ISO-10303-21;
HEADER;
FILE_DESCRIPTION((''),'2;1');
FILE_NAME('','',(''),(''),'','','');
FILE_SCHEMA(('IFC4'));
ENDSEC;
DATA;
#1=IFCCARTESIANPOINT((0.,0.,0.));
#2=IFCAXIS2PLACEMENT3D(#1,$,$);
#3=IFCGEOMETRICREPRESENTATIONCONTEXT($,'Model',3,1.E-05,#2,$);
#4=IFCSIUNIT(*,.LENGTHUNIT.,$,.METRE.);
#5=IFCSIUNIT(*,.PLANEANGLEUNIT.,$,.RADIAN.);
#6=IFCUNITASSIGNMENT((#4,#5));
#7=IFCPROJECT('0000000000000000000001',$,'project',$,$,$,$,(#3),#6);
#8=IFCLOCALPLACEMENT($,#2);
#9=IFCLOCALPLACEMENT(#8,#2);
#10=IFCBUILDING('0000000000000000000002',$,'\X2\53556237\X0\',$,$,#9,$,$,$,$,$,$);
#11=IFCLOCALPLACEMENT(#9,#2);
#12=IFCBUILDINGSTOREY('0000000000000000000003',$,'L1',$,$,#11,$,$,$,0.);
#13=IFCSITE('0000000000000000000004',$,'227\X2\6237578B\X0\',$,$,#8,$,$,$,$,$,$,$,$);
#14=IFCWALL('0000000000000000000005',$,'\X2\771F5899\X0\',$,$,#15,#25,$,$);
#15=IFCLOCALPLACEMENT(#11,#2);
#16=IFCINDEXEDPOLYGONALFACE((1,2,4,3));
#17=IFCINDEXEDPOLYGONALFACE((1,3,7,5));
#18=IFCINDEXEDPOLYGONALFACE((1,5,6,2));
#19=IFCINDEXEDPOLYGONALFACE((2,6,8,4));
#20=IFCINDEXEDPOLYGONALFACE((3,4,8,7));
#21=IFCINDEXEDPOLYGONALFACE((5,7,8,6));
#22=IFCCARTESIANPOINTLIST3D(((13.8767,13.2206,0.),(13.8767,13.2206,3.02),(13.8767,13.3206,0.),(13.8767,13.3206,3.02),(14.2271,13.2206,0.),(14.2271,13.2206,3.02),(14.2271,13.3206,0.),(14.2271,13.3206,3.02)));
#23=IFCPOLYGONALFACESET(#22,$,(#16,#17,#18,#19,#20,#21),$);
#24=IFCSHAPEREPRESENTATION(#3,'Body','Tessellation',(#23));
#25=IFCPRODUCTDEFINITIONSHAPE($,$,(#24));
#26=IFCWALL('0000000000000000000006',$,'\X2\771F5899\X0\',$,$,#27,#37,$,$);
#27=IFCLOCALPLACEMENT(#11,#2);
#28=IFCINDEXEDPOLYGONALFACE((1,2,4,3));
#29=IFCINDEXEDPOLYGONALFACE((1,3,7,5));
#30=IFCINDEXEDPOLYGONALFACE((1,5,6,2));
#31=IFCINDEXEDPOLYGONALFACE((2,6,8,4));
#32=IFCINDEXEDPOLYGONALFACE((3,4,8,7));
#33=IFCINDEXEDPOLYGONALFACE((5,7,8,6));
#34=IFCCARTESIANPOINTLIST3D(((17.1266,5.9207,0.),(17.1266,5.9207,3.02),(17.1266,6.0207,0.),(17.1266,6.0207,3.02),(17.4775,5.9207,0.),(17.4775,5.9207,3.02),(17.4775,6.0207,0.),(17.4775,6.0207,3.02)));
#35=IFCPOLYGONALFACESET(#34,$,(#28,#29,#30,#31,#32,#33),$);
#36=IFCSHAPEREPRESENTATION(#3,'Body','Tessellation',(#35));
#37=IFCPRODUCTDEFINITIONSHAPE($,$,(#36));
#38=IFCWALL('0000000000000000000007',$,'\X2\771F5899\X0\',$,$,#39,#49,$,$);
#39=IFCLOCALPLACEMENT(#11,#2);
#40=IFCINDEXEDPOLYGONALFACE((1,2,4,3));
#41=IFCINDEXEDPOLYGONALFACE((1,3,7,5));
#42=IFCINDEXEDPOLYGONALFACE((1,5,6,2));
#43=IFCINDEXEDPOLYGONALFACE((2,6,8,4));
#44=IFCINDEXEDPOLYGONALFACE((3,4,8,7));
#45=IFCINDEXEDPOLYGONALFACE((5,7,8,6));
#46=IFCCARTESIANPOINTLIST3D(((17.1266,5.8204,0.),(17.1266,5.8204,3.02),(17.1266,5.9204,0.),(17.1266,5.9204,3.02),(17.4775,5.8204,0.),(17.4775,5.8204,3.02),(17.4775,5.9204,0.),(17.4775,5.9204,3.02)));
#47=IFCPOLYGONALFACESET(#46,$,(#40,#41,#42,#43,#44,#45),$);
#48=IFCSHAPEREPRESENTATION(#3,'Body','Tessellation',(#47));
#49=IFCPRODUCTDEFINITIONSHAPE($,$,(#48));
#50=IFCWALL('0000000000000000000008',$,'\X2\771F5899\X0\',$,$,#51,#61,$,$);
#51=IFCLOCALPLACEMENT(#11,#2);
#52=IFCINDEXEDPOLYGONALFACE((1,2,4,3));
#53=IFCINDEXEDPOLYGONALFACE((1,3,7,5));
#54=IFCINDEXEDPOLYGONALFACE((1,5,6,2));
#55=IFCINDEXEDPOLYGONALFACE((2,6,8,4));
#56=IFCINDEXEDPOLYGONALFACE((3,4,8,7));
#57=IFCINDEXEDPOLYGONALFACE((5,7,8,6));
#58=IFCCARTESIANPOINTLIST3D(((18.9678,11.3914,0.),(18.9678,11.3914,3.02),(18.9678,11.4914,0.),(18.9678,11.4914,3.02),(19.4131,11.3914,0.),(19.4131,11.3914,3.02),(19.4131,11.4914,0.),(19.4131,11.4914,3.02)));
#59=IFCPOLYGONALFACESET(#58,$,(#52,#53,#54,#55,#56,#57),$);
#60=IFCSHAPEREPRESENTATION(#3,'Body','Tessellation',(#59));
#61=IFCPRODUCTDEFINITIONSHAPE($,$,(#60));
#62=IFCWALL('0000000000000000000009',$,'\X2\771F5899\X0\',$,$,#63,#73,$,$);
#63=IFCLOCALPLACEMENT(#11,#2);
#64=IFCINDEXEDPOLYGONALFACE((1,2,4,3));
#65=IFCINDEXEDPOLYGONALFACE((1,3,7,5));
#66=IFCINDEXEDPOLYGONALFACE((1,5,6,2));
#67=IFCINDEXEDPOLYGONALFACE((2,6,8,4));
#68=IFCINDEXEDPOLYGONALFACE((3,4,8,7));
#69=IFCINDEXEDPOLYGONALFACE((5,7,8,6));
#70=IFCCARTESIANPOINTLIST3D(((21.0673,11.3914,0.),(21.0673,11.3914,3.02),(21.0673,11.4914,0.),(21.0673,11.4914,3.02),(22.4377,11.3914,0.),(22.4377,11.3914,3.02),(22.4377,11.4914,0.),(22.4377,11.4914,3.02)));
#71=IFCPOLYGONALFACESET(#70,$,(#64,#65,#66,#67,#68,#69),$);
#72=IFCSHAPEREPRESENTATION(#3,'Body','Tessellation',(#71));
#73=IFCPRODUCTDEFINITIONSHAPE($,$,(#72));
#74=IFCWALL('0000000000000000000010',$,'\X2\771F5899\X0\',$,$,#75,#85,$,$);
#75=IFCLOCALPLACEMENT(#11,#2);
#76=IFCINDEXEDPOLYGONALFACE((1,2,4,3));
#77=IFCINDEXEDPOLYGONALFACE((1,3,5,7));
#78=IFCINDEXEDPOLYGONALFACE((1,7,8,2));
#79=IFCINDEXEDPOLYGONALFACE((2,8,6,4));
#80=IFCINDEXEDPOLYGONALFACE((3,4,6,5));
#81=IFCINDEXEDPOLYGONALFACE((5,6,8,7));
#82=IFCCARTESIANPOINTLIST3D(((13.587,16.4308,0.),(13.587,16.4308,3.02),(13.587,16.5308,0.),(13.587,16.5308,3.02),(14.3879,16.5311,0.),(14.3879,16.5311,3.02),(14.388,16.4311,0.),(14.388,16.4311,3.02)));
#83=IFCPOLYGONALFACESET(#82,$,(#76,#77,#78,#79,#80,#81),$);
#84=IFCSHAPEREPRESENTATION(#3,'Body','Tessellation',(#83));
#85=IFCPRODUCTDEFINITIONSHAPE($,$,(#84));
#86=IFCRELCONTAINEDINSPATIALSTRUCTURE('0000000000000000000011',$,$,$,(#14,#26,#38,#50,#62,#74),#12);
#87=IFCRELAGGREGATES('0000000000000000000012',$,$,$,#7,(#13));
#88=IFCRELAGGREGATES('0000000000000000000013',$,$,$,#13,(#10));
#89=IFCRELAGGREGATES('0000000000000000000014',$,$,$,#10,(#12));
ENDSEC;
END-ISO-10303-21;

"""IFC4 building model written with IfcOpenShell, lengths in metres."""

from ifc_helpers import new_model, si_unit, origin, place, context, project, spatial, polyline, outline, extrude, element, save


model = new_model("IFC4")

# Units and contexts
model_context = context("Model", 3, precision=1e-05, world=origin())
ifc_project = project(units=[si_unit("LENGTHUNIT", "METRE"), si_unit("PLANEANGLEUNIT", "RADIAN")], contexts=[model_context])

# Site, building, storey
site_placement = place(None, origin())
site = spatial("IfcSite", under=ifc_project, at=site_placement, Name="227户型")
building_placement = place(site_placement, origin())
building = spatial("IfcBuilding", under=site, at=building_placement, Name="单户")
storey_placement = place(building_placement, origin())
storey = spatial("IfcBuildingStorey", under=building, at=storey_placement, Name="L1", Elevation=0.0)

# Walls
wall_1_placement = place(storey_placement, origin())
element("IfcWall", 1, at=wall_1_placement, inside=storey, Name="真墙", context=model_context, shape_type="SweptSolid", body=[
    extrude(outline(polyline([(13.8767, 13.3206), (14.2271, 13.3206), (14.2271, 13.2206), (13.8767, 13.2206), (13.8767, 13.3206)])), origin(), (0.0, 0.0, 1.0), 3.02),
])
wall_2_placement = place(storey_placement, origin())
element("IfcWall", 2, at=wall_2_placement, inside=storey, Name="真墙", context=model_context, shape_type="SweptSolid", body=[
    extrude(outline(polyline([(17.4775, 5.9207), (17.1266, 5.9207), (17.1266, 6.0207), (17.4775, 6.0207), (17.4775, 5.9207)])), origin(), (0.0, 0.0, 1.0), 3.02),
])
wall_3_placement = place(storey_placement, origin())
element("IfcWall", 3, at=wall_3_placement, inside=storey, Name="真墙", context=model_context, shape_type="SweptSolid", body=[
    extrude(outline(polyline([(17.1266, 5.9204), (17.4775, 5.9204), (17.4775, 5.8204), (17.1266, 5.8204), (17.1266, 5.9204)])), origin(), (0.0, 0.0, 1.0), 3.02),
])
wall_4_placement = place(storey_placement, origin())
element("IfcWall", 4, at=wall_4_placement, inside=storey, Name="真墙", context=model_context, shape_type="SweptSolid", body=[
    extrude(outline(polyline([(19.4131, 11.3914), (18.9678, 11.3914), (18.9678, 11.4914), (19.4131, 11.4914), (19.4131, 11.3914)])), origin(), (0.0, 0.0, 1.0), 3.02),
])

# Walls
wall_5_placement = place(storey_placement, origin())
element("IfcWall", 5, at=wall_5_placement, inside=storey, Name="真墙", context=model_context, shape_type="SweptSolid", body=[
    extrude(outline(polyline([(21.0673, 11.4914), (22.4377, 11.4914), (22.4377, 11.3914), (21.0673, 11.3914), (21.0673, 11.4914)])), origin(), (0.0, 0.0, 1.0), 3.02),
])
wall_6_placement = place(storey_placement, origin())
element("IfcWall", 6, at=wall_6_placement, inside=storey, Name="真墙", context=model_context, shape_type="SweptSolid", body=[
    extrude(outline(polyline([(13.587, 16.5308), (14.3879, 16.5311), (14.388, 16.4311), (13.587, 16.4308), (13.587, 16.5308)])), origin(), (0.0, 0.0, 1.0), 3.02),
])

save(model, "model.ifc")
